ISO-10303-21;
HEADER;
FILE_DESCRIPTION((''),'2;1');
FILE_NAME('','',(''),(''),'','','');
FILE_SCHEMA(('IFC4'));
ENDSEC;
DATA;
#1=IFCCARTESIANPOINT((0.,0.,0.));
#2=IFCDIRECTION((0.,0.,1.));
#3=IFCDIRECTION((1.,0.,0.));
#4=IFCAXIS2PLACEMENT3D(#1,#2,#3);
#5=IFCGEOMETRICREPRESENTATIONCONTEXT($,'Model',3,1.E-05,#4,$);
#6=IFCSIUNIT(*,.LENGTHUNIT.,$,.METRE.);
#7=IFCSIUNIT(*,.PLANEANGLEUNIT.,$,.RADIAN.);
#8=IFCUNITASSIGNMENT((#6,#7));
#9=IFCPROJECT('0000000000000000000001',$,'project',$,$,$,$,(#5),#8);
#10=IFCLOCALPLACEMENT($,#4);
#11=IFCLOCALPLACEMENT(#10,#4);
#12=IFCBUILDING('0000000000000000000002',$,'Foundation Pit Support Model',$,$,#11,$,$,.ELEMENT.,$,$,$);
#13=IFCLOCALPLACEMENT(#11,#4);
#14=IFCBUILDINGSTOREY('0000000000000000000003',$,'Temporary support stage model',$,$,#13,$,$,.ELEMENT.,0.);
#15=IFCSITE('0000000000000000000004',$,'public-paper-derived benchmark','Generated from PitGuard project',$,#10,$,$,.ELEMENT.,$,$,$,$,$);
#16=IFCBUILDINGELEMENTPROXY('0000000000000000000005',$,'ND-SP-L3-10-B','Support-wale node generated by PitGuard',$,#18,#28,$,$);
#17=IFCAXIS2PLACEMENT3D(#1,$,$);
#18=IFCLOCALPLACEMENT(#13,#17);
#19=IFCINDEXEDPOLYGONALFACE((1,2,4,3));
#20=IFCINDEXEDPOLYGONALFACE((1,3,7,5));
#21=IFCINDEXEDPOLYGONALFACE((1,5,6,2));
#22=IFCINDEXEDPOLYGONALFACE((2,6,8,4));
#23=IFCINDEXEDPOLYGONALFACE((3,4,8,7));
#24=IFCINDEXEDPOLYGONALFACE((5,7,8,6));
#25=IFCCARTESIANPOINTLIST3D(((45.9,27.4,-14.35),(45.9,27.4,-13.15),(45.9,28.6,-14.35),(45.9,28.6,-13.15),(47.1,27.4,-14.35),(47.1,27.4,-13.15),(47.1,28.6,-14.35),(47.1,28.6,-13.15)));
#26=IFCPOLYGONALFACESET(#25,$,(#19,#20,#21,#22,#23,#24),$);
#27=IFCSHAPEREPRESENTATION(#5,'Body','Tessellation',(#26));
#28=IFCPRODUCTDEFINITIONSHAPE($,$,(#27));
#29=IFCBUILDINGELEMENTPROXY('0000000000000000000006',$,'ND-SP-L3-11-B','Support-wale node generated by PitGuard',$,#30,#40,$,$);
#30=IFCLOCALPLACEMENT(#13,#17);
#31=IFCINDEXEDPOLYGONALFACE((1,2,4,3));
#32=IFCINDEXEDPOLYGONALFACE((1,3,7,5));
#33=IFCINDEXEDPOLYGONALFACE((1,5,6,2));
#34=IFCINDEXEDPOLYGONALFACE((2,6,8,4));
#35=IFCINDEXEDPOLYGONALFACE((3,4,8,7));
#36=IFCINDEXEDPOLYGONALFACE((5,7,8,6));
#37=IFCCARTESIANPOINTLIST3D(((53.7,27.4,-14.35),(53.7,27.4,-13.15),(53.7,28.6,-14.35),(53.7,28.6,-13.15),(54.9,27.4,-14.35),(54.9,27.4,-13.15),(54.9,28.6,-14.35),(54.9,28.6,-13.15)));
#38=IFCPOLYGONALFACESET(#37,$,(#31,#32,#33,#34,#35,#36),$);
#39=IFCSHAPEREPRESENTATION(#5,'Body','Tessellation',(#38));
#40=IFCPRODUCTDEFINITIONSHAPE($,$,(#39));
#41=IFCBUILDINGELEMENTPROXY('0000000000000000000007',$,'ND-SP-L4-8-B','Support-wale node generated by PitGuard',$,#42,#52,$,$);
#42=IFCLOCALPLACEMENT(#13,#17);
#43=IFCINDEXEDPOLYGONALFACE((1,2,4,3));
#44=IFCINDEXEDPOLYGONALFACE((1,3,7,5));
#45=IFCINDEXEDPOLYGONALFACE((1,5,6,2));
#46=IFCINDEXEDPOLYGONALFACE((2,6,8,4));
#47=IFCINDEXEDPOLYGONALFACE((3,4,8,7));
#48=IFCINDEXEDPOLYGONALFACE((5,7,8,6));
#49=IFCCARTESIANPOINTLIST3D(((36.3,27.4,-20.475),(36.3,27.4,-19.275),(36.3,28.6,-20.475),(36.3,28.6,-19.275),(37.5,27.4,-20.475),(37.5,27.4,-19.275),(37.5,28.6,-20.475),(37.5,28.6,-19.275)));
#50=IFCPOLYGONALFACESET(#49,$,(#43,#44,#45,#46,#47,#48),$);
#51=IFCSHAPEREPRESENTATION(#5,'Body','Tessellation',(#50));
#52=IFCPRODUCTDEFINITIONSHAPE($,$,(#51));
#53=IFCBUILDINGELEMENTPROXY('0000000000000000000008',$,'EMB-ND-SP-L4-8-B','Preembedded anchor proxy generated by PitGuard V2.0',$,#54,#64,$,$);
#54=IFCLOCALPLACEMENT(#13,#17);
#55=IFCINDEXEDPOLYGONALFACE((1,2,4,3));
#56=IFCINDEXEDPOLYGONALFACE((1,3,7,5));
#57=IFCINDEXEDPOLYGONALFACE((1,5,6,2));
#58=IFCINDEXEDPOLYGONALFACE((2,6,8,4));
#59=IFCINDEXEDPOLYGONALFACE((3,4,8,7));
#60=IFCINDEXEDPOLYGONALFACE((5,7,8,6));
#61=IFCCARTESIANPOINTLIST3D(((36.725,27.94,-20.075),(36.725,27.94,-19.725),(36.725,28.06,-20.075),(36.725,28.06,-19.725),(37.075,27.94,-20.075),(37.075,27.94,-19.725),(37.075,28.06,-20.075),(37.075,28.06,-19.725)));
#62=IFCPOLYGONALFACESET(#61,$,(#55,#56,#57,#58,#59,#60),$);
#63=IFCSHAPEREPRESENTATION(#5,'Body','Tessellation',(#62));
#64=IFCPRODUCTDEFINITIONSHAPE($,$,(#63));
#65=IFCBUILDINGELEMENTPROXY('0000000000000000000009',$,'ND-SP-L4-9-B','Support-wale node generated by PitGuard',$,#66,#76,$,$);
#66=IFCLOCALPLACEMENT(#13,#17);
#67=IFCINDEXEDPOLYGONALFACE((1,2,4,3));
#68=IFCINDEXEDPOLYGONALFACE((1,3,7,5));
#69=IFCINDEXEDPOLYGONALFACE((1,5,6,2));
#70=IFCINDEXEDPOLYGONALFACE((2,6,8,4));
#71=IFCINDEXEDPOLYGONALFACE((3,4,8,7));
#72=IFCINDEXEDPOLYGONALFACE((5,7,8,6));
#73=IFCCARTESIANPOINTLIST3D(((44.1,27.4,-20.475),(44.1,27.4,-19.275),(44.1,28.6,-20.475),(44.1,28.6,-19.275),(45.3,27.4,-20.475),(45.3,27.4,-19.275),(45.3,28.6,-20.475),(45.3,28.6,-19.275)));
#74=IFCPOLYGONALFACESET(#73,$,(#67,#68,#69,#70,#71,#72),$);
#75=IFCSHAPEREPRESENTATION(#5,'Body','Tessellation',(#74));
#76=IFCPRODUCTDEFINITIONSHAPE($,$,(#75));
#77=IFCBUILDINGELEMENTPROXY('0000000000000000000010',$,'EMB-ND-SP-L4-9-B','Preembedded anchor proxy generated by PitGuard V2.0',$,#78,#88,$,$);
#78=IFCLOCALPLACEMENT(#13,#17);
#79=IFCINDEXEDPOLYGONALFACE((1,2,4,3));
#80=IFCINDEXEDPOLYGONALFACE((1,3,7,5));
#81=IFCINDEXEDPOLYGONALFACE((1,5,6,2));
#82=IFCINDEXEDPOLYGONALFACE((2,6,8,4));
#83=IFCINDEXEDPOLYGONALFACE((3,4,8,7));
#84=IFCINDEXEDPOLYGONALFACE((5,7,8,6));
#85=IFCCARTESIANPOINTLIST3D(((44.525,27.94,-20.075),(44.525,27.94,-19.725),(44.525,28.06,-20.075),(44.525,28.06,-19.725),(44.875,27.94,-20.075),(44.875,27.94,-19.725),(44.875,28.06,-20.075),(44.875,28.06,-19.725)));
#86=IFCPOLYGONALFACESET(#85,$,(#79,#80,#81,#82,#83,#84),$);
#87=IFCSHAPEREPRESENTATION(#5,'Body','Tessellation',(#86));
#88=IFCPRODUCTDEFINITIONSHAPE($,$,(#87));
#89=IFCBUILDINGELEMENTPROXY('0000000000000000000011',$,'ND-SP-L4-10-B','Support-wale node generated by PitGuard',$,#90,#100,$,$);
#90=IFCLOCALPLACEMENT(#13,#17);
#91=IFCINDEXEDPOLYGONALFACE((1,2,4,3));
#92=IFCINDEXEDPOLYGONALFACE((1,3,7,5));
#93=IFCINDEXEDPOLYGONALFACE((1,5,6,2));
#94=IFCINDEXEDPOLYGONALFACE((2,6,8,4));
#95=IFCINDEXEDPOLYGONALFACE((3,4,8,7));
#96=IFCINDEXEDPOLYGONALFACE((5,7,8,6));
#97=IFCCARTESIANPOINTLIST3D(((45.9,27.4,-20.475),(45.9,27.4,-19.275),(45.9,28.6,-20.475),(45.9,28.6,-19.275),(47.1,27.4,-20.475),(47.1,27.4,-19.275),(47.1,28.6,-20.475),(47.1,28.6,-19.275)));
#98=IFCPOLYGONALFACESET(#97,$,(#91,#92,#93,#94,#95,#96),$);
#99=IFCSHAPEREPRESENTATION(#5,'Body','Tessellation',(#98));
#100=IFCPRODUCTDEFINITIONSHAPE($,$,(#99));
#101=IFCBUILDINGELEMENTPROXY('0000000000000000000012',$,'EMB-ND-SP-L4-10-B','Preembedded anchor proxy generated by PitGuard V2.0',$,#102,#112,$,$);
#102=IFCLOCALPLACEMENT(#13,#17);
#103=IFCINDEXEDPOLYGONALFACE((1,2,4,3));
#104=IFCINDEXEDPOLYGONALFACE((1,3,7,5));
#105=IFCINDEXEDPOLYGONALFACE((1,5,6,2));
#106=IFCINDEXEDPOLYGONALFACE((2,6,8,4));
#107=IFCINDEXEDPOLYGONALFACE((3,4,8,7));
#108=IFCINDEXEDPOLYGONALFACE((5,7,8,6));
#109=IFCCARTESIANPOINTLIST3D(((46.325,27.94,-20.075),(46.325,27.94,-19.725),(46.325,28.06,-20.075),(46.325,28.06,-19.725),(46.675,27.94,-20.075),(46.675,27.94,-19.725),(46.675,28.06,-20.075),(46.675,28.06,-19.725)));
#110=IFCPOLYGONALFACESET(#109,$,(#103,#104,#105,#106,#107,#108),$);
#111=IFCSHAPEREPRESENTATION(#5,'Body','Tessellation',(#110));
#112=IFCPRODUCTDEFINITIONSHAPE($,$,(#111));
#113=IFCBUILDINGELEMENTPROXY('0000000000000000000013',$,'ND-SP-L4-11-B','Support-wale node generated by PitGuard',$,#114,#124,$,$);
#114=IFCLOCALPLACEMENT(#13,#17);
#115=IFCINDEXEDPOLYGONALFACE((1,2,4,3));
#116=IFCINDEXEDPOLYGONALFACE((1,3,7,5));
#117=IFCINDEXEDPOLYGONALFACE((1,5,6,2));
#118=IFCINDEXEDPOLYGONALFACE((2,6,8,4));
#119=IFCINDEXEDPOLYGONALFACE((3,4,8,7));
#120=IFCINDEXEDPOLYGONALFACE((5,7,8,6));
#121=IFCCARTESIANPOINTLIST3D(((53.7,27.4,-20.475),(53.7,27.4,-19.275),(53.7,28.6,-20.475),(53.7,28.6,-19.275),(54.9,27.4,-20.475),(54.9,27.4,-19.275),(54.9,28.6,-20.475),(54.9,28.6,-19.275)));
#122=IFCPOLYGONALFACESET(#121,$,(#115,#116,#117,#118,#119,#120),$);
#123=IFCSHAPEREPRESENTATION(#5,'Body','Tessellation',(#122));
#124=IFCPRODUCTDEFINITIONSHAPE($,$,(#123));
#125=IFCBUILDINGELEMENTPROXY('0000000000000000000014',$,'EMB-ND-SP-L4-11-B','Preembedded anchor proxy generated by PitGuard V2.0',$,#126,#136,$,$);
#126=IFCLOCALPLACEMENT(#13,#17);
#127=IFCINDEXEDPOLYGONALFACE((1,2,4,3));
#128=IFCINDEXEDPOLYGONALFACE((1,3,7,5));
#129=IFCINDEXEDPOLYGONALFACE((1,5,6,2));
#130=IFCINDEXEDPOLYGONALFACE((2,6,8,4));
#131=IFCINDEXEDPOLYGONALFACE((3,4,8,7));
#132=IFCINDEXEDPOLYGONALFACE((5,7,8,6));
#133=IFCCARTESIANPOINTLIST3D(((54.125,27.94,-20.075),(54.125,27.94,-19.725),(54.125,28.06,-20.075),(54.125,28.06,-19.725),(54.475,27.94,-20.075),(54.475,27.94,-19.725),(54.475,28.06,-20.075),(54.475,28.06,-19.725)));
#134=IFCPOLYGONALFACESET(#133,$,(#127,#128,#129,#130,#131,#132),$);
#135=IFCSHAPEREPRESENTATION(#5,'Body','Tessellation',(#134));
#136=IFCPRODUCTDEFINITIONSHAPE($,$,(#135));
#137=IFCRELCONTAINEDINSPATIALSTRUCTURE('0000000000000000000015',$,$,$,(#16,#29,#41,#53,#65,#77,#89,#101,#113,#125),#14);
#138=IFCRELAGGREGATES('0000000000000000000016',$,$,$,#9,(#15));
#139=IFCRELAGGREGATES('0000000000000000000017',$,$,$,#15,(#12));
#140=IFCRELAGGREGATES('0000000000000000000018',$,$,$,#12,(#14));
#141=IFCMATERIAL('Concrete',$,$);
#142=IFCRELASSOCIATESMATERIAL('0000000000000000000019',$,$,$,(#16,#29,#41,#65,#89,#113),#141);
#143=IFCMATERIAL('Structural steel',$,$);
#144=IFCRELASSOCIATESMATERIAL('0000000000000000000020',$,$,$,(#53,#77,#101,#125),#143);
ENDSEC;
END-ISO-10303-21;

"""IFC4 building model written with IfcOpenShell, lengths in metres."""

from ifc_helpers import new_model, si_unit, frame, origin_with_axes, origin_2d, place, context, project, spatial, rectangle, extrude, material, element, save


model = new_model("IFC4")

# Units and contexts
model_context = context("Model", 3, precision=1e-05, world=origin_with_axes())
ifc_project = project(units=[si_unit("LENGTHUNIT", "METRE"), si_unit("PLANEANGLEUNIT", "RADIAN")], contexts=[model_context])

# Site, building, storey
site_placement = place(None, origin_with_axes())
site = spatial("IfcSite", under=ifc_project, at=site_placement, Name="public-paper-derived benchmark", Description="Generated from PitGuard project", CompositionType="ELEMENT")
building_placement = place(site_placement, origin_with_axes())
building = spatial("IfcBuilding", under=site, at=building_placement, Name="Foundation Pit Support Model", CompositionType="ELEMENT")
storey_placement = place(building_placement, origin_with_axes())
storey = spatial("IfcBuildingStorey", under=building, at=storey_placement, Name="Temporary support stage model", CompositionType="ELEMENT", Elevation=0.0)

# Shared definitions
ifc_material_1 = material(Name="Concrete")

# Shared definitions
ifc_material_2 = material(Name="Structural steel")

# Building element proxies
for number, where, z_axis, x_axis, name in (
    (1, (46.5, 28.0, -14.35), (0.0, 0.0, 1.0), (1.0, 0.0, 0.0), "ND-SP-L3-10-B"),
    (2, (54.3, 28.0, -14.35), (0.0, 0.0, 1.0), (1.0, 0.0, 0.0), "ND-SP-L3-11-B"),
    (3, (36.9, 28.0, -20.475), (0.0, 0.0, 1.0), (1.0, 0.0, 0.0), "ND-SP-L4-8-B"),
):
    element("IfcBuildingElementProxy", number, at=place(storey_placement, frame(where, z_axis=z_axis, x_axis=x_axis)), inside=storey, material=ifc_material_1, Name=name, Description="Support-wale node generated by PitGuard", context=model_context, shape_type="SweptSolid", body=[
        extrude(rectangle(XDim=1.2, YDim=1.2, at=origin_2d()), origin_with_axes(), (0.0, 0.0, 1.0), 1.2),
    ])
proxy_1_placement = place(storey_placement, frame((36.9, 28.0, -20.075), z_axis=(0.0, 0.0, 1.0), x_axis=(1.0, 0.0, 0.0)))
element("IfcBuildingElementProxy", 4, at=proxy_1_placement, inside=storey, material=ifc_material_2, Name="EMB-ND-SP-L4-8-B", Description="Preembedded anchor proxy generated by PitGuard V2.0", context=model_context, shape_type="SweptSolid", body=[
    extrude(rectangle(XDim=0.35, YDim=0.12, at=origin_2d()), origin_with_axes(), (0.0, 0.0, 1.0), 0.35),
])
proxy_2_placement = place(storey_placement, frame((44.7, 28.0, -20.475), z_axis=(0.0, 0.0, 1.0), x_axis=(1.0, 0.0, 0.0)))
element("IfcBuildingElementProxy", 5, at=proxy_2_placement, inside=storey, material=ifc_material_1, Name="ND-SP-L4-9-B", Description="Support-wale node generated by PitGuard", context=model_context, shape_type="SweptSolid", body=[
    extrude(rectangle(XDim=1.2, YDim=1.2, at=origin_2d()), origin_with_axes(), (0.0, 0.0, 1.0), 1.2),
])
proxy_3_placement = place(storey_placement, frame((44.7, 28.0, -20.075), z_axis=(0.0, 0.0, 1.0), x_axis=(1.0, 0.0, 0.0)))
element("IfcBuildingElementProxy", 6, at=proxy_3_placement, inside=storey, material=ifc_material_2, Name="EMB-ND-SP-L4-9-B", Description="Preembedded anchor proxy generated by PitGuard V2.0", context=model_context, shape_type="SweptSolid", body=[
    extrude(rectangle(XDim=0.35, YDim=0.12, at=origin_2d()), origin_with_axes(), (0.0, 0.0, 1.0), 0.35),
])
proxy_4_placement = place(storey_placement, frame((46.5, 28.0, -20.475), z_axis=(0.0, 0.0, 1.0), x_axis=(1.0, 0.0, 0.0)))
element("IfcBuildingElementProxy", 7, at=proxy_4_placement, inside=storey, material=ifc_material_1, Name="ND-SP-L4-10-B", Description="Support-wale node generated by PitGuard", context=model_context, shape_type="SweptSolid", body=[
    extrude(rectangle(XDim=1.2, YDim=1.2, at=origin_2d()), origin_with_axes(), (0.0, 0.0, 1.0), 1.2),
])
proxy_5_placement = place(storey_placement, frame((46.5, 28.0, -20.075), z_axis=(0.0, 0.0, 1.0), x_axis=(1.0, 0.0, 0.0)))
element("IfcBuildingElementProxy", 8, at=proxy_5_placement, inside=storey, material=ifc_material_2, Name="EMB-ND-SP-L4-10-B", Description="Preembedded anchor proxy generated by PitGuard V2.0", context=model_context, shape_type="SweptSolid", body=[
    extrude(rectangle(XDim=0.35, YDim=0.12, at=origin_2d()), origin_with_axes(), (0.0, 0.0, 1.0), 0.35),
])
proxy_6_placement = place(storey_placement, frame((54.3, 28.0, -20.475), z_axis=(0.0, 0.0, 1.0), x_axis=(1.0, 0.0, 0.0)))
element("IfcBuildingElementProxy", 9, at=proxy_6_placement, inside=storey, material=ifc_material_1, Name="ND-SP-L4-11-B", Description="Support-wale node generated by PitGuard", context=model_context, shape_type="SweptSolid", body=[
    extrude(rectangle(XDim=1.2, YDim=1.2, at=origin_2d()), origin_with_axes(), (0.0, 0.0, 1.0), 1.2),
])
proxy_7_placement = place(storey_placement, frame((54.3, 28.0, -20.075), z_axis=(0.0, 0.0, 1.0), x_axis=(1.0, 0.0, 0.0)))
element("IfcBuildingElementProxy", 10, at=proxy_7_placement, inside=storey, material=ifc_material_2, Name="EMB-ND-SP-L4-11-B", Description="Preembedded anchor proxy generated by PitGuard V2.0", context=model_context, shape_type="SweptSolid", body=[
    extrude(rectangle(XDim=0.35, YDim=0.12, at=origin_2d()), origin_with_axes(), (0.0, 0.0, 1.0), 0.35),
])

save(model, "model.ifc")
